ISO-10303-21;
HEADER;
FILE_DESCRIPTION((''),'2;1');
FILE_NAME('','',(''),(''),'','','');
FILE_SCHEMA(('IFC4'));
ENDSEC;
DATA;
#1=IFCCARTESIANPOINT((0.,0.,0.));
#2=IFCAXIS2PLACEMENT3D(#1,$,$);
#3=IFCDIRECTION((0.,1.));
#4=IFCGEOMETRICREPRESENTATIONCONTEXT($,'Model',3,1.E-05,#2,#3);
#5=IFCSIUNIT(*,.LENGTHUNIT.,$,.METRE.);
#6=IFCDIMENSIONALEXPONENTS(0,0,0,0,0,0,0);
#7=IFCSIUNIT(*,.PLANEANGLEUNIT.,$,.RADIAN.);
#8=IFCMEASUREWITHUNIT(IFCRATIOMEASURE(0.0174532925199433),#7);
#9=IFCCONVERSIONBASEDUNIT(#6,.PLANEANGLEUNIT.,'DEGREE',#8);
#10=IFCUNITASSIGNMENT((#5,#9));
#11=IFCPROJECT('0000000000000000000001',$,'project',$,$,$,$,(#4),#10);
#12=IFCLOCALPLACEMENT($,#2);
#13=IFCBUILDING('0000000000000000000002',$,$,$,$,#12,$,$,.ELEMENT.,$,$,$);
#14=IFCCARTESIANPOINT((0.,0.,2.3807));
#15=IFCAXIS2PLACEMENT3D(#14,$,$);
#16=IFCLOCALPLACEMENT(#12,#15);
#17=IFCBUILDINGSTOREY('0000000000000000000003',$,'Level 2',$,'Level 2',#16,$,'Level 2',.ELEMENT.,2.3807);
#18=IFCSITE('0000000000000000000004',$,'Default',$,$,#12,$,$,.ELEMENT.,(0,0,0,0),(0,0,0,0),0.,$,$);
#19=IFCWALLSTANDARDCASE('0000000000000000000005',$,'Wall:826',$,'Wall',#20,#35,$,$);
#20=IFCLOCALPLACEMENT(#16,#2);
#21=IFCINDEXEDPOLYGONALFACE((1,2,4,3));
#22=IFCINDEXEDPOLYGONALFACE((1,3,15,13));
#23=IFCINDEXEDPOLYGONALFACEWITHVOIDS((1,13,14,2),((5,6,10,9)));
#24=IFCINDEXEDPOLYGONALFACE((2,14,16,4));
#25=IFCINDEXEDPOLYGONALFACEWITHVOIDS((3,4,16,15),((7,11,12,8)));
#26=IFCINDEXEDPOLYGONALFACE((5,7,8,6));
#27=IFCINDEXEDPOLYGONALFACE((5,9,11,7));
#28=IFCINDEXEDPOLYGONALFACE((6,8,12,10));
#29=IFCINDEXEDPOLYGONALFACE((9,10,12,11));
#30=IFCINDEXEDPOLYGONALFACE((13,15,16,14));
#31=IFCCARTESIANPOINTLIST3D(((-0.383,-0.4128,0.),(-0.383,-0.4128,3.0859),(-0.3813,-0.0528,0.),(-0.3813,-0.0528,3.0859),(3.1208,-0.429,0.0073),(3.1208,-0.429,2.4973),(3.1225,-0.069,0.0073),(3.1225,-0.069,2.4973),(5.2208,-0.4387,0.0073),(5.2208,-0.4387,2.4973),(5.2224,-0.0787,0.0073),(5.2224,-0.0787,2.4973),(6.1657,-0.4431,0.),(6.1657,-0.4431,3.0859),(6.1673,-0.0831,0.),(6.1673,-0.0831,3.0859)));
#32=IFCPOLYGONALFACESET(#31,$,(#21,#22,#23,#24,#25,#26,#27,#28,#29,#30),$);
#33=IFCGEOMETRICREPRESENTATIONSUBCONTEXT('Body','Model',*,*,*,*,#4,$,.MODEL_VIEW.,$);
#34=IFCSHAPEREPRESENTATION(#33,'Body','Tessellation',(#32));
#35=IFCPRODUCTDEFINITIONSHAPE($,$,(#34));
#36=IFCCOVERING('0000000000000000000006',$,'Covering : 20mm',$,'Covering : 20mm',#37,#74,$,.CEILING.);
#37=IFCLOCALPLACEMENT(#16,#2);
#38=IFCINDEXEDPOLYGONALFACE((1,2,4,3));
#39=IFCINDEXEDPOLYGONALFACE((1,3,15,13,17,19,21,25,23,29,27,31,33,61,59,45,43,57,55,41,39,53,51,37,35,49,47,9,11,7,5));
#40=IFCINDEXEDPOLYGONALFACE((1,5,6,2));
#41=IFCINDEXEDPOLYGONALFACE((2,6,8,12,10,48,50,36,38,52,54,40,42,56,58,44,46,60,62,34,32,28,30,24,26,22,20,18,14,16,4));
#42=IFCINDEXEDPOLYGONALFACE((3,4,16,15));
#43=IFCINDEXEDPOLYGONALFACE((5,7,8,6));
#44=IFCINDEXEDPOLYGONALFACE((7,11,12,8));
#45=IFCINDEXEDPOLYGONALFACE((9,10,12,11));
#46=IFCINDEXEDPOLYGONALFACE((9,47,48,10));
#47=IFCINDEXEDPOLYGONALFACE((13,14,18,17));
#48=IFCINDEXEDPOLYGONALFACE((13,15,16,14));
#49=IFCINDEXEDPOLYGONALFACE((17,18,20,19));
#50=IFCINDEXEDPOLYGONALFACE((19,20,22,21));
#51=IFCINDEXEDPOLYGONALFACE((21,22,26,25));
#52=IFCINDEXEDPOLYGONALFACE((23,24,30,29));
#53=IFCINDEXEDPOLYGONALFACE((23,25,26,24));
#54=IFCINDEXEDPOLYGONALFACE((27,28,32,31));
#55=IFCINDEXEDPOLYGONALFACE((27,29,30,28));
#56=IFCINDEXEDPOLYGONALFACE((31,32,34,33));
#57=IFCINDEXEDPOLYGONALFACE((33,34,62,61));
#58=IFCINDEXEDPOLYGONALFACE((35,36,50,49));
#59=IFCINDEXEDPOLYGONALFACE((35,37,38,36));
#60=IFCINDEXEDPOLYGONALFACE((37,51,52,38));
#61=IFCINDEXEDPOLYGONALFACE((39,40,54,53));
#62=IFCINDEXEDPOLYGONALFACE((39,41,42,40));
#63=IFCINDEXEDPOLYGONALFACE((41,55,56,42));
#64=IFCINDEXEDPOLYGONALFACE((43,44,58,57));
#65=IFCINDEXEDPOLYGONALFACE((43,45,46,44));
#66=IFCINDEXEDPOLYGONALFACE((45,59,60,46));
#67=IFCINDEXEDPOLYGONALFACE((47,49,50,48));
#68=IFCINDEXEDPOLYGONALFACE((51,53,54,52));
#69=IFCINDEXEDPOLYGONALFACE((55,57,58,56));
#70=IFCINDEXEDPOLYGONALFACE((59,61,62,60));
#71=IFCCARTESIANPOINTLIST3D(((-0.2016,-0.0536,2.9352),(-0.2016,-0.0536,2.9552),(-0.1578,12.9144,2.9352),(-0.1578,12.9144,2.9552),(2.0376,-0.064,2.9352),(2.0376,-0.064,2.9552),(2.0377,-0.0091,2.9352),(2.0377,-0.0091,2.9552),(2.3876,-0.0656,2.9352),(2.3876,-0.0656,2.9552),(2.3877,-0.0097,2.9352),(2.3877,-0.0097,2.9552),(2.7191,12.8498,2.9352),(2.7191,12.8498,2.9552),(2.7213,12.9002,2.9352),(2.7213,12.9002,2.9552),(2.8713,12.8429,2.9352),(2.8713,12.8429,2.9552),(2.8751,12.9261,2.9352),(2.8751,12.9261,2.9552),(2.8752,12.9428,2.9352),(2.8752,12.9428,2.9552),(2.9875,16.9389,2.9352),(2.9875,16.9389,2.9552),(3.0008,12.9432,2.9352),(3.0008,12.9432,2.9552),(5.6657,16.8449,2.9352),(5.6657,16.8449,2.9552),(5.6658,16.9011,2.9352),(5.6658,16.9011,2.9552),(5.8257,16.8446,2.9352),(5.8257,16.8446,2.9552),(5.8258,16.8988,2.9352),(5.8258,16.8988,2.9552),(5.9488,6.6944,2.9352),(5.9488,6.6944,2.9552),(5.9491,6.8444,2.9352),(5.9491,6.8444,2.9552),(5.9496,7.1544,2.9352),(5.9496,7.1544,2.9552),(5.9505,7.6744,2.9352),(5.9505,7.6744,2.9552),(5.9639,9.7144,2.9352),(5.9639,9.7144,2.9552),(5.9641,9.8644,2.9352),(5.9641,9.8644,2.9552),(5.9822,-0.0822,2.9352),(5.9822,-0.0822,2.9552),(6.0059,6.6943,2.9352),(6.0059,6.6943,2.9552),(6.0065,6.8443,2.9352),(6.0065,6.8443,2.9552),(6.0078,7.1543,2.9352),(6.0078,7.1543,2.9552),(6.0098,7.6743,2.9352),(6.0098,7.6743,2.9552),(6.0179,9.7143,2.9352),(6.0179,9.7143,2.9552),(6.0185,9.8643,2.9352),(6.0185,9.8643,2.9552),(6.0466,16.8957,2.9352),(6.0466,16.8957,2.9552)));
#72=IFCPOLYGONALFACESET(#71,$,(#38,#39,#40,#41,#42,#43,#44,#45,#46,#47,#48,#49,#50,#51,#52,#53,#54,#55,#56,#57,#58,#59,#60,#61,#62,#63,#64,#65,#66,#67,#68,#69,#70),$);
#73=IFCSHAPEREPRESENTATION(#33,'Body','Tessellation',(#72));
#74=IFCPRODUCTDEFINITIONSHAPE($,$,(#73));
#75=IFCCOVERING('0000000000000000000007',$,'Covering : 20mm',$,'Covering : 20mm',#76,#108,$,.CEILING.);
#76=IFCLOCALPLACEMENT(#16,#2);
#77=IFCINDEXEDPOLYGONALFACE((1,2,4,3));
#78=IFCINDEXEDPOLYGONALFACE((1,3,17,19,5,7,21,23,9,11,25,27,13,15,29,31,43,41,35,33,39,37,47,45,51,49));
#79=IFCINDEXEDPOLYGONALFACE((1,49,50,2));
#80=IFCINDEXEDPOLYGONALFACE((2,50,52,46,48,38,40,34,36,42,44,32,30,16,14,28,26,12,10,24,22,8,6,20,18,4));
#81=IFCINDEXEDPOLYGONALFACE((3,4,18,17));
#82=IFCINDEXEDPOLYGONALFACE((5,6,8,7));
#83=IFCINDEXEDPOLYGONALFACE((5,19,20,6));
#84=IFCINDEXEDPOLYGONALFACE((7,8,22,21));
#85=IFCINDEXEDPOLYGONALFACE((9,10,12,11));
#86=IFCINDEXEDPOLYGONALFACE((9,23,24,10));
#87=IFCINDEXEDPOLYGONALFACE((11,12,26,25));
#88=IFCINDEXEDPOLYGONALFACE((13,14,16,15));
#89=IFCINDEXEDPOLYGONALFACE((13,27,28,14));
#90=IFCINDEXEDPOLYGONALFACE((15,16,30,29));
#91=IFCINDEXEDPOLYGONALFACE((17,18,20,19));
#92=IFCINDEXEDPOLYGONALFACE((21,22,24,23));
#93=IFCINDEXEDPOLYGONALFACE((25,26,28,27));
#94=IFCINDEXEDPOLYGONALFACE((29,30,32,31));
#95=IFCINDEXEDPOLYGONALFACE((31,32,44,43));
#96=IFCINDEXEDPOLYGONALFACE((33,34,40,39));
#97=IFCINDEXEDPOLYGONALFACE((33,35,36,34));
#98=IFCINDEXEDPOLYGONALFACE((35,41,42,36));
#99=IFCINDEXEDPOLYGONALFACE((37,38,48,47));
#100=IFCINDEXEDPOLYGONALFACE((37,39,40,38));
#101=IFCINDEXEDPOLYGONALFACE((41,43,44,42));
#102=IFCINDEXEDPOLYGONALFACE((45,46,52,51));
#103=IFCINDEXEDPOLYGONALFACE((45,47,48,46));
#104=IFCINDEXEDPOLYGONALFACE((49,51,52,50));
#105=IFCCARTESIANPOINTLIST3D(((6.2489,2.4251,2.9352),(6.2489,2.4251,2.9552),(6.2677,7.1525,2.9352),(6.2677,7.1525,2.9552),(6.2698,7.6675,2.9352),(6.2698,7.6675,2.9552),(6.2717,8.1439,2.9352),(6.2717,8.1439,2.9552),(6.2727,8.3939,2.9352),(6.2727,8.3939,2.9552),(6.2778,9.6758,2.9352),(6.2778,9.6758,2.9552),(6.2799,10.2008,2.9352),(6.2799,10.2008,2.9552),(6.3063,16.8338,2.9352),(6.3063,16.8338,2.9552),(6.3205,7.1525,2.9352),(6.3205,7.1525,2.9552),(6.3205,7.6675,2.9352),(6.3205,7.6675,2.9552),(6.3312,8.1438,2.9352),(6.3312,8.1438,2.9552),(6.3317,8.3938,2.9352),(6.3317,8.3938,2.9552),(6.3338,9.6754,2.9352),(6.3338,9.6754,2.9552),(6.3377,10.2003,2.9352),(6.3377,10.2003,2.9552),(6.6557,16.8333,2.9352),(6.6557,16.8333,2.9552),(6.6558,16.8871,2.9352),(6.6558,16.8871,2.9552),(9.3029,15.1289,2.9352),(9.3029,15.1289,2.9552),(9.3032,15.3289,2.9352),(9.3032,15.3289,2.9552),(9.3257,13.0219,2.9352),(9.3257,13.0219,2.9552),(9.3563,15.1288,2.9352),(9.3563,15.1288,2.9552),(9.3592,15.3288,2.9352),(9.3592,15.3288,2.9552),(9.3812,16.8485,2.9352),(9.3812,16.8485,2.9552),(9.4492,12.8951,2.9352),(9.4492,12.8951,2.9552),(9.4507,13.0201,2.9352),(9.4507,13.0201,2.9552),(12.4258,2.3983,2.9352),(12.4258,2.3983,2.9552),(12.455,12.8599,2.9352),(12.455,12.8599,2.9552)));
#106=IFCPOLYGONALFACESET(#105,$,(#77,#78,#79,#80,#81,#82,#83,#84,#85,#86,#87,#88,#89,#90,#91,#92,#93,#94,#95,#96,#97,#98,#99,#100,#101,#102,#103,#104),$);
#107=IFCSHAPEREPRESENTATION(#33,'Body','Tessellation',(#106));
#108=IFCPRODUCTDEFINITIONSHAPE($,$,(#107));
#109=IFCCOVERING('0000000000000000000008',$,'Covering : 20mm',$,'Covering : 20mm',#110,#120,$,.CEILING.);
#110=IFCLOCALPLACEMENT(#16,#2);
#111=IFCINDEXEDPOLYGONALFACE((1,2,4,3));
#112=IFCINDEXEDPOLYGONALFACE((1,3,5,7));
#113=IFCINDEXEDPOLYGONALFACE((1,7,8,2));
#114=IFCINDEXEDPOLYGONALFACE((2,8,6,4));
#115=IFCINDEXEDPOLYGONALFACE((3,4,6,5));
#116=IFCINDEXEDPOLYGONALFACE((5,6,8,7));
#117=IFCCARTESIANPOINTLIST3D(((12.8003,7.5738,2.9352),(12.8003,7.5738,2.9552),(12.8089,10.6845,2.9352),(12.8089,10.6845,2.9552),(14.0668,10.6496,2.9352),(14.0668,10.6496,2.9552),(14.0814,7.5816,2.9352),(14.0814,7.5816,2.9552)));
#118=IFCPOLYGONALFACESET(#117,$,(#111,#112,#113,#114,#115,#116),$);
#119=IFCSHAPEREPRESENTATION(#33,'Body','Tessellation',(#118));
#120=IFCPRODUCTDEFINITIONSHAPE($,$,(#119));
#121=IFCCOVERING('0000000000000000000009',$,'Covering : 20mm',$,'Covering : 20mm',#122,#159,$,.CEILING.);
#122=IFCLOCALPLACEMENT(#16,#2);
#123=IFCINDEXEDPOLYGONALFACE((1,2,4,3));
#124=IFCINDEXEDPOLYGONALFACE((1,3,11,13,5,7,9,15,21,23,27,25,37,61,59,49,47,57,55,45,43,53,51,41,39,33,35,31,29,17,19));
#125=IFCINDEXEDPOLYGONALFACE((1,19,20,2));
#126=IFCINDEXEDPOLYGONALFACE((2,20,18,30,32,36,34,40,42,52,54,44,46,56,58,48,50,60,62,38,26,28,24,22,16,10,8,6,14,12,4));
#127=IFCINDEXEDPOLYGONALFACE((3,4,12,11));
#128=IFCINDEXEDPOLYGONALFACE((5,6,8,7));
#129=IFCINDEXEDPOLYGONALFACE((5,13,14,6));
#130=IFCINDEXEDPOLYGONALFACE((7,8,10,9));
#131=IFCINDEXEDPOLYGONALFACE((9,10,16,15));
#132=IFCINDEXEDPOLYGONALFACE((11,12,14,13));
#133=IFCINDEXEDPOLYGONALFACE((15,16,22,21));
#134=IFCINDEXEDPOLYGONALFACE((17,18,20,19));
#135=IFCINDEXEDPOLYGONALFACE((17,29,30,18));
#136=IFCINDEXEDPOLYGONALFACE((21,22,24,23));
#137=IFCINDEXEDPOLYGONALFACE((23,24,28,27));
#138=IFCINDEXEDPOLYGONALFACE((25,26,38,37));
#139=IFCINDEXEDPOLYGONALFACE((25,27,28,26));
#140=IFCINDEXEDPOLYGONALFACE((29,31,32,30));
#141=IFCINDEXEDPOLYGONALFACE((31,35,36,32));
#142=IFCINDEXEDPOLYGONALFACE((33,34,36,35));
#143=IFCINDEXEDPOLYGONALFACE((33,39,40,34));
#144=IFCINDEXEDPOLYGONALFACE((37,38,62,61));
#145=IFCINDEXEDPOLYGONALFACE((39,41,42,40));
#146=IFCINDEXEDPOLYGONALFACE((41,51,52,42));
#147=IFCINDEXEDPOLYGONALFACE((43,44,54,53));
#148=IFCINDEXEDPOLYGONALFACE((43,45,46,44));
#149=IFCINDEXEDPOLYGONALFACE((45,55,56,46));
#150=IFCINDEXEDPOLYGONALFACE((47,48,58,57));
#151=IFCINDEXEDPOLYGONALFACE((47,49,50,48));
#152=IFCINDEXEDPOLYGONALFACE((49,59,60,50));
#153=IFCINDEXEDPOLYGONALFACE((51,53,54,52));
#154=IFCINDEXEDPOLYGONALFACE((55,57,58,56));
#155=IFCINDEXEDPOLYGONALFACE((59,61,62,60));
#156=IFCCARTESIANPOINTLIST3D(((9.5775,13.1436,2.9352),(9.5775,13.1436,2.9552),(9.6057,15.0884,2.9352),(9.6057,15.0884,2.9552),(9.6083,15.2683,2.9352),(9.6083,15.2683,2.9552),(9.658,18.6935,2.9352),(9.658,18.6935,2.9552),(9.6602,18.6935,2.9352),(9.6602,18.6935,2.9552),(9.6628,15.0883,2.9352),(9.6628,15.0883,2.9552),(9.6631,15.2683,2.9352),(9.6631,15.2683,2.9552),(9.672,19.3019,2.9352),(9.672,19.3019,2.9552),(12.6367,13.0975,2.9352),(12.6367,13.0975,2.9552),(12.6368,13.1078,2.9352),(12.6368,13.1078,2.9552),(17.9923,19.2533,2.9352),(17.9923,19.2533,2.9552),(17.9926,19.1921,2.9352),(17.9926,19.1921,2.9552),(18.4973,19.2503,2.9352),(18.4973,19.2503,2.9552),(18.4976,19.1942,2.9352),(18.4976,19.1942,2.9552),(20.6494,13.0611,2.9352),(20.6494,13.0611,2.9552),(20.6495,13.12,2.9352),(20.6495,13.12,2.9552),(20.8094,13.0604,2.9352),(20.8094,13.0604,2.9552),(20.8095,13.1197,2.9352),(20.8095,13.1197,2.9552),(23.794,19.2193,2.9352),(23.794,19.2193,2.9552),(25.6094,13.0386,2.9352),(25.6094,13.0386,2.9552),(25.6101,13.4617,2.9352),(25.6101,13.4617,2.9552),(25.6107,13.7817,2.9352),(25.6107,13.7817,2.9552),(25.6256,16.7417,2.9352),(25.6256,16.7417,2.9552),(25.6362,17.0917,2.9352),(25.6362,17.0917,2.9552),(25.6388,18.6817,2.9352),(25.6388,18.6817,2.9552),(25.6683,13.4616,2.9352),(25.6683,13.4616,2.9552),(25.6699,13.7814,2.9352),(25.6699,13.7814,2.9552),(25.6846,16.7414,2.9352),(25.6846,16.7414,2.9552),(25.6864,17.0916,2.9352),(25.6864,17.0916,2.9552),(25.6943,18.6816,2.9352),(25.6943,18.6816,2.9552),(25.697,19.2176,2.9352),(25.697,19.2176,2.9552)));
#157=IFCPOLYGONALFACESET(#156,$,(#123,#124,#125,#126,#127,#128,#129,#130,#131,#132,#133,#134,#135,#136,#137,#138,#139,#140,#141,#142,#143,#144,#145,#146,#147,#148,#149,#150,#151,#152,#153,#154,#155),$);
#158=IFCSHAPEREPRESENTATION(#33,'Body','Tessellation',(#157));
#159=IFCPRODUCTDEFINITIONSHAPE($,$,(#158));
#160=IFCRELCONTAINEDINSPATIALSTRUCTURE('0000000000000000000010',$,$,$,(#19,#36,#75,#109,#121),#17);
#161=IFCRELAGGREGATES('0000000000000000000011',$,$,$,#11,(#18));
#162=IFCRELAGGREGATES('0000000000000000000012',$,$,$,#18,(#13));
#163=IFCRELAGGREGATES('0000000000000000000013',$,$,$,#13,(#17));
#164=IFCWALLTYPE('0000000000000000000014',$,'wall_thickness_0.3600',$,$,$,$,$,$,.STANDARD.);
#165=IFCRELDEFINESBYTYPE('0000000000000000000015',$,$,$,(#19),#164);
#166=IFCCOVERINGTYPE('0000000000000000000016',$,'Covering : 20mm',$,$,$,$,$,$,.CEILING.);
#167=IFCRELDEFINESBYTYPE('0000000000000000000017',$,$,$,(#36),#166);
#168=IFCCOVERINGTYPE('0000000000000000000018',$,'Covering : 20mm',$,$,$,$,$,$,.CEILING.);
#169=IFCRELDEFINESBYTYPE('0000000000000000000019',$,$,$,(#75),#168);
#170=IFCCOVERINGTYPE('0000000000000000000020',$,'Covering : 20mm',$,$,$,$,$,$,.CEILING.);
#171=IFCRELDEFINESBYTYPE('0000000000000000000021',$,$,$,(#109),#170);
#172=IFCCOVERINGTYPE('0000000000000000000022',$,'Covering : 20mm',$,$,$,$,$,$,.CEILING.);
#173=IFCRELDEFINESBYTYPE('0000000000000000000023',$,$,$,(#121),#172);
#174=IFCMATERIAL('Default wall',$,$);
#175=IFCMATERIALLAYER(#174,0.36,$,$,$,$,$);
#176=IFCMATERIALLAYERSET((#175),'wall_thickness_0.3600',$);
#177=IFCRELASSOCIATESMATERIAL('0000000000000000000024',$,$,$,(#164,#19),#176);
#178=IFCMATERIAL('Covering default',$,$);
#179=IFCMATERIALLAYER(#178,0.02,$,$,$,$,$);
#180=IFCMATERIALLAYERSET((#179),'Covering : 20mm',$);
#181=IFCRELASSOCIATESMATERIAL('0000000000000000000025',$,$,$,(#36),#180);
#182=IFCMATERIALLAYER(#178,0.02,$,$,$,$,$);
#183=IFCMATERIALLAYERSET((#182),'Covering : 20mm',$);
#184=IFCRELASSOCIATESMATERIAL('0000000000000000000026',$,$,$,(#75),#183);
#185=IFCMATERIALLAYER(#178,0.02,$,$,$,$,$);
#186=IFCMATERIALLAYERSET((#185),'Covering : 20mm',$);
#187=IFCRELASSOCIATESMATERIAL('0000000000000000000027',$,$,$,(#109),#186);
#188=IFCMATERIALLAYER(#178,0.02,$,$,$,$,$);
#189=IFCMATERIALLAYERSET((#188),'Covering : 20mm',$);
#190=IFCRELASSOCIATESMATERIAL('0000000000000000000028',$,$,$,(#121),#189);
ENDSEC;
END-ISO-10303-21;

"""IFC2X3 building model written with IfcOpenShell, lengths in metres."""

from ifc_helpers import new_model, entity, si_unit, converted_unit, direction, frame, frame_2d, origin, origin_with_axes, place, context, subcontext, project, spatial, polyline, rectangle, outline, extrude, material, layer, layer_set, layer_usage, type_object, element, save


model = new_model("IFC2X3")

# Units and contexts
model_context = context("Model", 3, precision=1e-05, world=origin(), true_north=direction((0.0, 1.0)))
body_context = subcontext(model_context, "Body", "Model", "MODEL_VIEW")
ifc_project = project(units=[si_unit("LENGTHUNIT", "METRE"), converted_unit("PLANEANGLEUNIT", "DEGREE", entity("IfcRatioMeasure", 0.0174532925199433), si_unit("PLANEANGLEUNIT", "RADIAN"), dimensions=[0, 0, 0, 0, 0, 0, 0])], contexts=[model_context])

# Site, building, storey
placement = place(None, origin())
site = spatial("IfcSite", under=ifc_project, at=placement, Name="Default", CompositionType="ELEMENT", RefLatitude=(0, 0, 0, 0), RefLongitude=(0, 0, 0, 0), RefElevation=0.0)
building = spatial("IfcBuilding", under=site, at=placement, CompositionType="ELEMENT")
storey_placement = place(placement, frame((0.0, 0.0, 2.3807)))
storey = spatial("IfcBuildingStorey", under=building, at=storey_placement, Name="Level 2", ObjectType="Level 2", LongName="Level 2", CompositionType="ELEMENT", Elevation=2.3807)

# Wall, opening
ifc_material_1 = material(Name="Default wall")
ifc_layer_1 = layer(ifc_material_1, 0.36)
ifc_layer_set_1 = layer_set([ifc_layer_1], Name="wall_thickness_0.3600")
ifc_layer_usage_1 = layer_usage(ifc_layer_set_1, "AXIS2", "POSITIVE", -0.18)
wall_type = type_object("IfcWallType", Name="wall_thickness_0.3600", PredefinedType="STANDARD", material=ifc_layer_set_1)
wall_placement = place(storey_placement, frame((-0.3822, -0.2328, 0.0), z_axis=(0.0, 0.0, 1.0), x_axis=(0.999989, -0.004627, 0.0)))
wall = element("IfcWallStandardCase", 1, at=wall_placement, inside=storey, type_object=wall_type, material=ifc_layer_usage_1, Name="Wall:826", ObjectType="Wall", context=body_context, shape_type="SweptSolid", body=[
    extrude(outline(polyline([(6.5487, -0.18), (6.5487, 0.18), (0.0, 0.18), (0.0, -0.18), (6.5487, -0.18)])), origin(), (0.0, 0.0, 1.0), 3.0859),
])
opening_placement = place(wall_placement, frame((3.5038, -0.18, 0.0073)))
element("IfcOpeningElement", 2, at=opening_placement, cuts=wall, ObjectType="Opening", context=body_context, shape_type="SweptSolid", body=[
    extrude(rectangle(XDim=2.1, YDim=2.49, at=frame_2d((1.245, 1.05), x_axis=(0.0, 1.0))), frame((0.0, 0.0, 0.0), z_axis=(0.0, 1.0, 0.0), x_axis=(0.0, 0.0, 1.0)), (0.0, 0.0, 1.0), 0.36),
])

# Coverings
ifc_material_2 = material(Name="Covering default")
ifc_layer_2 = layer(ifc_material_2, 0.02)
ifc_layer_set_2 = layer_set([ifc_layer_2], Name="Covering : 20mm")
ifc_layer_usage_2 = layer_usage(ifc_layer_set_2, "AXIS3", "POSITIVE", 0.0)
covering_type_1 = type_object("IfcCoveringType", Name="Covering : 20mm", PredefinedType="CEILING")
covering_1_placement = place(placement, frame((0.0, 0.0, 5.3159)))
element("IfcCovering", 3, at=covering_1_placement, inside=storey, type_object=covering_type_1, material=ifc_layer_usage_2, Name="Covering : 20mm", ObjectType="Covering : 20mm", PredefinedType="CEILING", context=body_context, shape_type="SweptSolid", body=[
    extrude(outline(polyline([(-0.1578, 12.9144), (2.7213, 12.9002), (2.7191, 12.8498), (2.8713, 12.8429), (2.8751, 12.9261), (2.8752, 12.9428), (3.0008, 12.9432), (2.9875, 16.9389), (5.6658, 16.9011), (5.6657, 16.8449), (5.8257, 16.8446), (5.8258, 16.8988), (6.0466, 16.8957), (6.0185, 9.8643), (5.9641, 9.8644), (5.9639, 9.7144), (6.0179, 9.7143), (6.0098, 7.6743), (5.9505, 7.6744), (5.9496, 7.1544), (6.0078, 7.1543), (6.0065, 6.8443), (5.9491, 6.8444), (5.9488, 6.6944), (6.0059, 6.6943), (5.9822, -0.0822), (2.3876, -0.0656), (2.3877, -0.0097), (2.0377, -0.0091), (2.0376, -0.064), (-0.2016, -0.0536), (-0.1578, 12.9144)])), origin_with_axes(), (0.0, 0.0, 1.0), 0.02),
])
ifc_layer_3 = layer(ifc_material_2, 0.02)
ifc_layer_set_3 = layer_set([ifc_layer_3], Name="Covering : 20mm")
ifc_layer_usage_3 = layer_usage(ifc_layer_set_3, "AXIS3", "POSITIVE", 0.0)
covering_type_2 = type_object("IfcCoveringType", Name="Covering : 20mm", PredefinedType="CEILING")
covering_2_placement = place(placement, frame((0.0, 0.0, 5.3159)))
element("IfcCovering", 4, at=covering_2_placement, inside=storey, type_object=covering_type_2, material=ifc_layer_usage_3, Name="Covering : 20mm", ObjectType="Covering : 20mm", PredefinedType="CEILING", context=body_context, shape_type="SweptSolid", body=[
    extrude(outline(polyline([(6.2677, 7.1525), (6.3205, 7.1525), (6.3205, 7.6675), (6.2698, 7.6675), (6.2717, 8.1439), (6.3312, 8.1438), (6.3317, 8.3938), (6.2727, 8.3939), (6.2778, 9.6758), (6.3338, 9.6754), (6.3377, 10.2003), (6.2799, 10.2008), (6.3063, 16.8338), (6.6557, 16.8333), (6.6558, 16.8871), (9.3812, 16.8485), (9.3592, 15.3288), (9.3032, 15.3289), (9.3029, 15.1289), (9.3563, 15.1288), (9.3257, 13.0219), (9.4507, 13.0201), (9.4492, 12.8951), (12.455, 12.8599), (12.4258, 2.3983), (6.2489, 2.4251), (6.2677, 7.1525)])), origin_with_axes(), (0.0, 0.0, 1.0), 0.02),
])
ifc_layer_4 = layer(ifc_material_2, 0.02)
ifc_layer_set_4 = layer_set([ifc_layer_4], Name="Covering : 20mm")
ifc_layer_usage_4 = layer_usage(ifc_layer_set_4, "AXIS3", "POSITIVE", 0.0)
covering_type_3 = type_object("IfcCoveringType", Name="Covering : 20mm", PredefinedType="CEILING")
covering_3_placement = place(placement, frame((0.0, 0.0, 5.3159)))
element("IfcCovering", 5, at=covering_3_placement, inside=storey, type_object=covering_type_3, material=ifc_layer_usage_4, Name="Covering : 20mm", ObjectType="Covering : 20mm", PredefinedType="CEILING", context=body_context, shape_type="SweptSolid", body=[
    extrude(outline(polyline([(12.8089, 10.6845), (14.0668, 10.6496), (14.0814, 7.5816), (12.8003, 7.5738), (12.8089, 10.6845)])), origin_with_axes(), (0.0, 0.0, 1.0), 0.02),
])
ifc_layer_5 = layer(ifc_material_2, 0.02)
ifc_layer_set_5 = layer_set([ifc_layer_5], Name="Covering : 20mm")
ifc_layer_usage_5 = layer_usage(ifc_layer_set_5, "AXIS3", "POSITIVE", 0.0)
covering_type_4 = type_object("IfcCoveringType", Name="Covering : 20mm", PredefinedType="CEILING")
covering_4_placement = place(placement, frame((0.0, 0.0, 5.3159)))
element("IfcCovering", 6, at=covering_4_placement, inside=storey, type_object=covering_type_4, material=ifc_layer_usage_5, Name="Covering : 20mm", ObjectType="Covering : 20mm", PredefinedType="CEILING", context=body_context, shape_type="SweptSolid", body=[
    extrude(outline(polyline([(9.6057, 15.0884), (9.6628, 15.0883), (9.6631, 15.2683), (9.6083, 15.2683), (9.658, 18.6935), (9.6602, 18.6935), (9.672, 19.3019), (17.9923, 19.2533), (17.9926, 19.1921), (18.4976, 19.1942), (18.4973, 19.2503), (23.794, 19.2193), (25.697, 19.2176), (25.6943, 18.6816), (25.6388, 18.6817), (25.6362, 17.0917), (25.6864, 17.0916), (25.6846, 16.7414), (25.6256, 16.7417), (25.6107, 13.7817), (25.6699, 13.7814), (25.6683, 13.4616), (25.6101, 13.4617), (25.6094, 13.0386), (20.8094, 13.0604), (20.8095, 13.1197), (20.6495, 13.12), (20.6494, 13.0611), (12.6367, 13.0975), (12.6368, 13.1078), (9.5775, 13.1436), (9.6057, 15.0884)])), origin_with_axes(), (0.0, 0.0, 1.0), 0.02),
])

save(model, "model.ifc")
